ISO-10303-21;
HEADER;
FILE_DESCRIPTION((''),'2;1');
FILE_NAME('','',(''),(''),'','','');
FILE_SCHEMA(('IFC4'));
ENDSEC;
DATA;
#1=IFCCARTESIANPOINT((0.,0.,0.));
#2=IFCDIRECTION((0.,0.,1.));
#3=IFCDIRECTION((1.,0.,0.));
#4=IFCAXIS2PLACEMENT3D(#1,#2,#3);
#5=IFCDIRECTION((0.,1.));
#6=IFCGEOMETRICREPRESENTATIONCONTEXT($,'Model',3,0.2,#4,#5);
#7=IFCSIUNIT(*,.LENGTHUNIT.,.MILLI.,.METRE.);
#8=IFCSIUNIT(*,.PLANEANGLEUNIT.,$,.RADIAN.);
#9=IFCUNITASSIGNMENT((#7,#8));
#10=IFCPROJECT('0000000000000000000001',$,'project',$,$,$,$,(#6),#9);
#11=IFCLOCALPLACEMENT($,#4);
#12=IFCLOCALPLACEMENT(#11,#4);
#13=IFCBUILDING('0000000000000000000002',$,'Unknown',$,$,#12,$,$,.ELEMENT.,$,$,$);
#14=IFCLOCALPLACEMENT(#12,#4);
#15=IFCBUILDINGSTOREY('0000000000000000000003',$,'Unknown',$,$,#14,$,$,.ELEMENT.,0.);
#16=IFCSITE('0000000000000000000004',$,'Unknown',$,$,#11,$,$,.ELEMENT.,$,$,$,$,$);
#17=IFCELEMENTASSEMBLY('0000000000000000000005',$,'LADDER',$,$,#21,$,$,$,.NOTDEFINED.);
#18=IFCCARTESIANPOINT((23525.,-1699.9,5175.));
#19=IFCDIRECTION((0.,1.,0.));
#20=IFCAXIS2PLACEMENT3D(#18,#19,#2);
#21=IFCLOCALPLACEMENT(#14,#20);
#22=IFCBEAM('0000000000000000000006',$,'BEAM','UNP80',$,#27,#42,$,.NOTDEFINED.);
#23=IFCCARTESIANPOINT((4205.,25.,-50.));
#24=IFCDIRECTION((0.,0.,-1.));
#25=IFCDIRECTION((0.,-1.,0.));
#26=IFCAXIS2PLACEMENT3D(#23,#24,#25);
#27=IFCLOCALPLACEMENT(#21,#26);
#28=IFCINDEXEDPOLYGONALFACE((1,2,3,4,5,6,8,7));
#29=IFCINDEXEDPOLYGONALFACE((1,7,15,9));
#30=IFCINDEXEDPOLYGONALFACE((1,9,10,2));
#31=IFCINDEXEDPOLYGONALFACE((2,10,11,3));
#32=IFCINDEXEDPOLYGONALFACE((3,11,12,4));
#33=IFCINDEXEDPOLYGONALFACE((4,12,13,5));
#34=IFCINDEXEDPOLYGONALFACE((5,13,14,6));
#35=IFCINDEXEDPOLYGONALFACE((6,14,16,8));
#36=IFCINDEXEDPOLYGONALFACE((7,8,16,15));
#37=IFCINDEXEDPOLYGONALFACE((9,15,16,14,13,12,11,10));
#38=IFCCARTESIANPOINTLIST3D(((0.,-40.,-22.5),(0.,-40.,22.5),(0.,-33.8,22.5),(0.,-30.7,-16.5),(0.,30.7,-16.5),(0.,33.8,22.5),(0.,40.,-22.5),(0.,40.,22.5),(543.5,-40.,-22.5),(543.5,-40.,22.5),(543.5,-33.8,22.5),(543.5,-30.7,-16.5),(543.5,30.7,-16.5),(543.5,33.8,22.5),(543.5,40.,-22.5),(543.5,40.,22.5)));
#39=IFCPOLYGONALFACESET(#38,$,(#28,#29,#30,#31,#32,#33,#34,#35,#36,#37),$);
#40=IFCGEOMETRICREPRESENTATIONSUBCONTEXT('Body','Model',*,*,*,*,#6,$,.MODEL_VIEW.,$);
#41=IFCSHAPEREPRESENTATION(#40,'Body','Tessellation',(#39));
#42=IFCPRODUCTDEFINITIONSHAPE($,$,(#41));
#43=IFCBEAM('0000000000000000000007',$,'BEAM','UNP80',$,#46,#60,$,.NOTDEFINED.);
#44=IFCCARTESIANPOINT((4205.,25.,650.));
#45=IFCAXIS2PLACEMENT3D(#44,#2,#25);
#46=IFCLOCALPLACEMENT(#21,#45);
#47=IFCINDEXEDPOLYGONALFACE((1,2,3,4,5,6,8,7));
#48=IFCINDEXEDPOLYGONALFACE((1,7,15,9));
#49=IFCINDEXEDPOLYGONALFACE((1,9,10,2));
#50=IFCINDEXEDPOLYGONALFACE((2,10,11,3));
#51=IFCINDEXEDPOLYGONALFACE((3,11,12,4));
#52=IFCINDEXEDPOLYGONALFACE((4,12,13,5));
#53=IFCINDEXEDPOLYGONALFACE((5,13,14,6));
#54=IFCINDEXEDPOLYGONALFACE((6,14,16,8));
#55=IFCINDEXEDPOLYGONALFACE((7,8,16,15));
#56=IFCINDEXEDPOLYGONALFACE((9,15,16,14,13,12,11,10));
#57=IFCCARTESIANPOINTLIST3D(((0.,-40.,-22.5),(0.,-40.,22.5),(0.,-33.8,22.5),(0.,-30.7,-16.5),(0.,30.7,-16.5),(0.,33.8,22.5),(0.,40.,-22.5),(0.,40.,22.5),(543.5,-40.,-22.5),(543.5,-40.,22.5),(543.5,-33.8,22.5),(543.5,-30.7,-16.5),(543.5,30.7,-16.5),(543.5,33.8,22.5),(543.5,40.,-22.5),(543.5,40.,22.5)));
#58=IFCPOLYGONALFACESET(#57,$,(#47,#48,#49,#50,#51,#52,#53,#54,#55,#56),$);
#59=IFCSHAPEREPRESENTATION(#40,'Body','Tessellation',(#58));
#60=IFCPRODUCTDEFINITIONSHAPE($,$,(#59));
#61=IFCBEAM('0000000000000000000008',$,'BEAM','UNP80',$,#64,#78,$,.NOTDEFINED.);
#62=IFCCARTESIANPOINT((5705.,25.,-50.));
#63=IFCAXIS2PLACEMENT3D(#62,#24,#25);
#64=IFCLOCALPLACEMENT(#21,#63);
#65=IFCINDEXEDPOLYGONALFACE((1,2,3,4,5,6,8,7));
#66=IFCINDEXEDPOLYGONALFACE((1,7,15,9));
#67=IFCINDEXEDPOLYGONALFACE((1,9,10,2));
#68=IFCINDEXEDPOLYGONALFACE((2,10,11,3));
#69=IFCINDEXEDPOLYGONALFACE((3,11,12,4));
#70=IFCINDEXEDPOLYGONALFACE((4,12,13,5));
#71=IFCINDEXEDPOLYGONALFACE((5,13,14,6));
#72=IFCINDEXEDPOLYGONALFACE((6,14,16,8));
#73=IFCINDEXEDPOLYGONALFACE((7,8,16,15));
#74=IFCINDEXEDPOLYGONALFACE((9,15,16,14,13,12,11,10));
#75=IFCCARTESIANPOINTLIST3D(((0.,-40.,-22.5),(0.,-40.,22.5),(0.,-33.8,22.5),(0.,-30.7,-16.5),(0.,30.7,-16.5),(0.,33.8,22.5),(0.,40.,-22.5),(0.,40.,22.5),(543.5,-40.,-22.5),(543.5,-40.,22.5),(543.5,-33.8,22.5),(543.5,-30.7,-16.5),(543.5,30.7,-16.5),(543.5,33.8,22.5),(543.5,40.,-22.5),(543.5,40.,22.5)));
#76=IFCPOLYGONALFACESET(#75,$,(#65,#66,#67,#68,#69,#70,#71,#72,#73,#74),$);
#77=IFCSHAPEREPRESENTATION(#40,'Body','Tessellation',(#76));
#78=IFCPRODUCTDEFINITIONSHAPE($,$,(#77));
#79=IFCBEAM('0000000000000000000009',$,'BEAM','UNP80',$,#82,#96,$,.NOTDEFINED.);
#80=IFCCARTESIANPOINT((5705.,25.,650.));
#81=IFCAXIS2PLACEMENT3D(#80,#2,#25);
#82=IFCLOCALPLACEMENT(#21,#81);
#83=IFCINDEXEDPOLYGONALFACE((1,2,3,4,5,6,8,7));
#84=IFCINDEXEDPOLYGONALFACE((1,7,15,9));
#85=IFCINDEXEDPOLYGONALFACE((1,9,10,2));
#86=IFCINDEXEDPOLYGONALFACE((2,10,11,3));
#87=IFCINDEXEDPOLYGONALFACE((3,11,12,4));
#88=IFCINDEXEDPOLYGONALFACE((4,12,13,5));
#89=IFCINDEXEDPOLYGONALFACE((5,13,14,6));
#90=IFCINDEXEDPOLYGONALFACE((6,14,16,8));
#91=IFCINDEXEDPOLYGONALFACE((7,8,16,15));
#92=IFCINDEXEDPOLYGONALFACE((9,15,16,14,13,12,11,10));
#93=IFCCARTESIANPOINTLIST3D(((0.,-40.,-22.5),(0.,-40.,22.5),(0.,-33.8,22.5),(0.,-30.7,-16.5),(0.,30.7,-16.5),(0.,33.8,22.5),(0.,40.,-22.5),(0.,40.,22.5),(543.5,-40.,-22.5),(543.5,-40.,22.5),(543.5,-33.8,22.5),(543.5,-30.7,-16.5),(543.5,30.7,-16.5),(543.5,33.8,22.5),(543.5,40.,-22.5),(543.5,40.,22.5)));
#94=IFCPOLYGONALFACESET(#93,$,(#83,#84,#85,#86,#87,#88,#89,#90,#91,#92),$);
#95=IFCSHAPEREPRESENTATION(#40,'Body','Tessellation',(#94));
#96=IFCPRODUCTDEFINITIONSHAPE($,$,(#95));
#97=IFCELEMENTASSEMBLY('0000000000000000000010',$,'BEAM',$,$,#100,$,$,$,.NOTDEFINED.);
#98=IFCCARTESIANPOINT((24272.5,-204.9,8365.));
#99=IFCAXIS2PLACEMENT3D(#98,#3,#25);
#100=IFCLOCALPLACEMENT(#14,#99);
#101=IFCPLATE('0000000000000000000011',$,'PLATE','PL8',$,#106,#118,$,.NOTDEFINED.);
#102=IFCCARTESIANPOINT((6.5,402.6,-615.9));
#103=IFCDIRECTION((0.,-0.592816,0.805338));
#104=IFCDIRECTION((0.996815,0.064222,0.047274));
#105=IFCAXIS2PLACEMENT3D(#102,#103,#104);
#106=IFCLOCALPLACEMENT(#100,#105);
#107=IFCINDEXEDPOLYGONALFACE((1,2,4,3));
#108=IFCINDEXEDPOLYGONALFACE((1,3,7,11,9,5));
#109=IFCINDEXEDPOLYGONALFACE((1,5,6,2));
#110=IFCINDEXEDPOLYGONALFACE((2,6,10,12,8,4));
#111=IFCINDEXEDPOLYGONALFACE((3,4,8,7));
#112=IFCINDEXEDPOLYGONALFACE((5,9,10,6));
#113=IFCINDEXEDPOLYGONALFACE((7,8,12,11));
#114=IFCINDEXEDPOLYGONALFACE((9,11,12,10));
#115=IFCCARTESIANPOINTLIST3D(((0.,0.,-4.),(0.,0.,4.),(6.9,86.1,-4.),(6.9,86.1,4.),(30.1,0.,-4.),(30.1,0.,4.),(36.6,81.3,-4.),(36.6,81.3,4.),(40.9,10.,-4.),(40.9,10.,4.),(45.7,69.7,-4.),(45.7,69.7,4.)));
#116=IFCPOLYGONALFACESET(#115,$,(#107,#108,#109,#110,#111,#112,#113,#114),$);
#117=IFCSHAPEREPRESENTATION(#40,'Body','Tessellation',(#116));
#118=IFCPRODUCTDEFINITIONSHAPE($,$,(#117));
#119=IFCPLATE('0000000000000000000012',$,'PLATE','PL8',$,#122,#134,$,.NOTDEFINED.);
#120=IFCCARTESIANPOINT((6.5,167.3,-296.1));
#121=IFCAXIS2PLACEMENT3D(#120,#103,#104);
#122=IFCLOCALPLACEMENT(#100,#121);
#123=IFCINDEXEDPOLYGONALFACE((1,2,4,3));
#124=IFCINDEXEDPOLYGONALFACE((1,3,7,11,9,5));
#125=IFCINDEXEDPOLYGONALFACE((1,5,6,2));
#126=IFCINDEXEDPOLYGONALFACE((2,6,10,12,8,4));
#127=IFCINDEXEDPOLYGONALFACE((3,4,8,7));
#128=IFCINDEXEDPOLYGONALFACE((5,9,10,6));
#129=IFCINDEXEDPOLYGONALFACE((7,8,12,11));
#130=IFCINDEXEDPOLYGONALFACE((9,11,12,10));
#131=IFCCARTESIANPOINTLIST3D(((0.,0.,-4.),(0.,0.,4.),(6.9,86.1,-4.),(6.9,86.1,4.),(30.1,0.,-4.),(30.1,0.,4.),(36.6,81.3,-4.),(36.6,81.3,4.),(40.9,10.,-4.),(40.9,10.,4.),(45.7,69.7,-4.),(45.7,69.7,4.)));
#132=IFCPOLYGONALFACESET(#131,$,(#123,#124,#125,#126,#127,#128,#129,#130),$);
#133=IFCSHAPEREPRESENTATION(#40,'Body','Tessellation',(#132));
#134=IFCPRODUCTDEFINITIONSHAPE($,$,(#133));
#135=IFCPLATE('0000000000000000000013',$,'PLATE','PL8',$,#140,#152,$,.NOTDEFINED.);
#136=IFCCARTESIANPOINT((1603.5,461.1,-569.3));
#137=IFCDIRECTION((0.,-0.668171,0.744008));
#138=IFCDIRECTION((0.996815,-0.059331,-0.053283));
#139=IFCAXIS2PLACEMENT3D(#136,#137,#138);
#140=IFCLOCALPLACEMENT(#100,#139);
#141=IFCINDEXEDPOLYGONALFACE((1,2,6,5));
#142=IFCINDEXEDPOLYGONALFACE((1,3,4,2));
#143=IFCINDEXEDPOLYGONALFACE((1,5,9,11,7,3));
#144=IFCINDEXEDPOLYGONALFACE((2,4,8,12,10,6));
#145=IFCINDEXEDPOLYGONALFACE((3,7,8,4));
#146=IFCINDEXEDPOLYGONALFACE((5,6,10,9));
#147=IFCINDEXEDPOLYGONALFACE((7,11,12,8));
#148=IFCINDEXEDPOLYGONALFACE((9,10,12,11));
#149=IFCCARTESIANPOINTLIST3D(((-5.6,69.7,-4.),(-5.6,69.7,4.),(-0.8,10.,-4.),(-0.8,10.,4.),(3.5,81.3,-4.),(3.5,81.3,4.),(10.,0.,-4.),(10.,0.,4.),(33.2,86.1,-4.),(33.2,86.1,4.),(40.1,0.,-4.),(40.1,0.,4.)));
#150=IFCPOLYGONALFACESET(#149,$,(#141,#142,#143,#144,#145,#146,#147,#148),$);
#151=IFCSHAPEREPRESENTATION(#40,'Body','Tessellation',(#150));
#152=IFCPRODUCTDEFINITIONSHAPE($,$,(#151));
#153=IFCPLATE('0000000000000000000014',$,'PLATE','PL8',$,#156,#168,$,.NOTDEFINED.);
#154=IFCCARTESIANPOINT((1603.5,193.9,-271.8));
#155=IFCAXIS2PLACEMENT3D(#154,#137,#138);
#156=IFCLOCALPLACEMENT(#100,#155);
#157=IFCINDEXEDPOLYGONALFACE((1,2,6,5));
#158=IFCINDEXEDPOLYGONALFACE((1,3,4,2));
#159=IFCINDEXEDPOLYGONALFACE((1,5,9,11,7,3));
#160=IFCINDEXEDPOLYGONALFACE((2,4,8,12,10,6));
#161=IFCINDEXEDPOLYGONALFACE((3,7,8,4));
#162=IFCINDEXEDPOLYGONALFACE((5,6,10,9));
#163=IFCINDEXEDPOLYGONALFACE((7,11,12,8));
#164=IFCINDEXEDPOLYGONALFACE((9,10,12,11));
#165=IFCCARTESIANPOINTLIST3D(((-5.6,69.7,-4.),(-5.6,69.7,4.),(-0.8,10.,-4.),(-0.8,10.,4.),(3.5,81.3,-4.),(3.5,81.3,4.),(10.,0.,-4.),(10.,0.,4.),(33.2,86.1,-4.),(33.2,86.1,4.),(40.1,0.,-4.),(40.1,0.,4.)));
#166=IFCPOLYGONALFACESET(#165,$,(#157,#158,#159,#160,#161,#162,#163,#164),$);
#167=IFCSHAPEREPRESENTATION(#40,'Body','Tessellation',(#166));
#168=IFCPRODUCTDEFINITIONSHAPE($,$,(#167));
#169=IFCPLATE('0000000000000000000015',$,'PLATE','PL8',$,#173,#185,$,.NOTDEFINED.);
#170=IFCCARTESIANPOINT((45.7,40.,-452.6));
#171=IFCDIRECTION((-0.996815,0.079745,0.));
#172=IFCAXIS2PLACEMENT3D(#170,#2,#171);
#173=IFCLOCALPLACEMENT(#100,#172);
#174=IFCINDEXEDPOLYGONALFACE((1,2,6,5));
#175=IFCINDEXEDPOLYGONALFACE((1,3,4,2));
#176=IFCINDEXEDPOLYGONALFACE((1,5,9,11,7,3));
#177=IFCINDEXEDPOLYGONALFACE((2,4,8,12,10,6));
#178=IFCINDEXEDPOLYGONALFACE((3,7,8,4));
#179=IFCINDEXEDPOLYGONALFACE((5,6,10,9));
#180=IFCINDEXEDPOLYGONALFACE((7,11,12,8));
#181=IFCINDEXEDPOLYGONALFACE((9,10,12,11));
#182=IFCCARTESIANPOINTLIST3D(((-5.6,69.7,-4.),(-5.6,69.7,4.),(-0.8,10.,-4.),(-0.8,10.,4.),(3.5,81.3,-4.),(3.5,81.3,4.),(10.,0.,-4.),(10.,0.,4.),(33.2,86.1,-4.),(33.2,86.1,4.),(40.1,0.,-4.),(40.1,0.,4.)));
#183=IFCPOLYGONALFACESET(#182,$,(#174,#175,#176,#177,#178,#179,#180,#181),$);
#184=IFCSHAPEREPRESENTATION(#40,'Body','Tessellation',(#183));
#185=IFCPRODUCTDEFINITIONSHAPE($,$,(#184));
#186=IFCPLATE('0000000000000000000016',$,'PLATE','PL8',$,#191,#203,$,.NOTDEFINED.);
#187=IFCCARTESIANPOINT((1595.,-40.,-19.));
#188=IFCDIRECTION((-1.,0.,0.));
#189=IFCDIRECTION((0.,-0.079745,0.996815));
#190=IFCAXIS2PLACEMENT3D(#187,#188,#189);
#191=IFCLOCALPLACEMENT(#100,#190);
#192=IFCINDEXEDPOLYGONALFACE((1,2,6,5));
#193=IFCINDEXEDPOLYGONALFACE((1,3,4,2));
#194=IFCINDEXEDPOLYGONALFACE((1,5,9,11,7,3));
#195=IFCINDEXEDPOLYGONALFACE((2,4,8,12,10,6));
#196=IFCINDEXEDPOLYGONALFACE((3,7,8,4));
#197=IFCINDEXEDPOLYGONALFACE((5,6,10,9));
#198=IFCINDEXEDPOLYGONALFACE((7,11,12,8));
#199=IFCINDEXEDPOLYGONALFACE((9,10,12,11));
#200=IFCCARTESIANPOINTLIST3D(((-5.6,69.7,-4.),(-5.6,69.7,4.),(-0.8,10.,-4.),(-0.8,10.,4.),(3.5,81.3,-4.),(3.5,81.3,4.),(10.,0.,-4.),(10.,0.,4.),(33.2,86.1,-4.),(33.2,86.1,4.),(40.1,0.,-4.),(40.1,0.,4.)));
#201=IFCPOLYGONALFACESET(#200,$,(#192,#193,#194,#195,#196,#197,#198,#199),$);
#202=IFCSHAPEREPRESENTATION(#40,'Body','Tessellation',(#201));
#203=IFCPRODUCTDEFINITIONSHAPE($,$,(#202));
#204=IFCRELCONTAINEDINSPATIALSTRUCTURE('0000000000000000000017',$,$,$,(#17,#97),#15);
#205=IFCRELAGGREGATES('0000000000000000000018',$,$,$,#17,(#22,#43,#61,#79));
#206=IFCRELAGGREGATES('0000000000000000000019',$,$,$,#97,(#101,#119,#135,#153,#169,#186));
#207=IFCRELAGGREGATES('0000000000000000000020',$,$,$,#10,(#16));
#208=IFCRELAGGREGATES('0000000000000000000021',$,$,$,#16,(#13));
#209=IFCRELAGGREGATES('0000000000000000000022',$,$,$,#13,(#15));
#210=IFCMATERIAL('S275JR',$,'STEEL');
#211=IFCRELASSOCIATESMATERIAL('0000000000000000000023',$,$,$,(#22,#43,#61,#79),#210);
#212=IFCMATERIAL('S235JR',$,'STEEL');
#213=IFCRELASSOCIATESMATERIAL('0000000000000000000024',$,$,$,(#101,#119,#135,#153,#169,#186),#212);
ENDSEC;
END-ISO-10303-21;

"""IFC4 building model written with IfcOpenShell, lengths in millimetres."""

from ifc_helpers import new_model, si_unit, direction, frame, origin_with_axes, place, context, subcontext, project, spatial, line, indexed_curve, outline, extrude, material, element, aggregate, save


model = new_model("IFC4")

# Units and contexts
model_context = context("Model", 3, precision=0.2, world=origin_with_axes(), true_north=direction((0.0, 1.0)))
body_context = subcontext(model_context, "Body", "Model", "MODEL_VIEW")
ifc_project = project(units=[si_unit("LENGTHUNIT", "METRE", prefix="MILLI"), si_unit("PLANEANGLEUNIT", "RADIAN")], contexts=[model_context])

# Site, building, storey
site_placement = place(None, origin_with_axes())
site = spatial("IfcSite", under=ifc_project, at=site_placement, Name="Unknown", CompositionType="ELEMENT")
building_placement = place(site_placement, origin_with_axes())
building = spatial("IfcBuilding", under=site, at=building_placement, Name="Unknown", CompositionType="ELEMENT")
storey_placement = place(building_placement, origin_with_axes())
storey = spatial("IfcBuildingStorey", under=building, at=storey_placement, Name="Unknown", CompositionType="ELEMENT", Elevation=0.0)

# Element assembly, beams
assembly_1_placement = place(storey_placement, frame((23525.0, -1699.9, 5175.0), z_axis=(0.0, 1.0, 0.0), x_axis=(0.0, 0.0, 1.0)))
assembly_1 = element("IfcElementAssembly", 1, at=assembly_1_placement, inside=storey, Name="LADDER", PredefinedType="NOTDEFINED")
ifc_material_1 = material(Name="S275JR", Category="STEEL")
beam_1_placement = place(assembly_1_placement, frame((4205.0, 25.0, -50.0), z_axis=(0.0, 0.0, -1.0), x_axis=(0.0, -1.0, 0.0)))
beam_1 = element("IfcBeam", 2, at=beam_1_placement, material=ifc_material_1, Name="BEAM", Description="UNP80", PredefinedType="NOTDEFINED", context=body_context, shape_type="SolidModel", body=[
    extrude(outline(indexed_curve([(-22.5, -40.0), (22.5, -40.0), (22.5, -33.8), (-16.5, -30.7), (-16.5, 30.7), (22.5, 33.8), (22.5, 40.0), (-22.5, 40.0)], segments=[line(1, 2, 3, 4, 5, 6, 7, 8, 1)])), frame((0.0, 0.0, 0.0), z_axis=(-1.0, 0.0, 0.0), x_axis=(0.0, 0.0, 1.0)), (0.0, 0.0, -1.0), 543.5),
])
beam_2_placement = place(assembly_1_placement, frame((4205.0, 25.0, 650.0), z_axis=(0.0, 0.0, 1.0), x_axis=(0.0, -1.0, 0.0)))
beam_2 = element("IfcBeam", 3, at=beam_2_placement, material=ifc_material_1, Name="BEAM", Description="UNP80", PredefinedType="NOTDEFINED", context=body_context, shape_type="SolidModel", body=[
    extrude(outline(indexed_curve([(-22.5, -40.0), (22.5, -40.0), (22.5, -33.8), (-16.5, -30.7), (-16.5, 30.7), (22.5, 33.8), (22.5, 40.0), (-22.5, 40.0)], segments=[line(1, 2, 3, 4, 5, 6, 7, 8, 1)])), frame((0.0, 0.0, 0.0), z_axis=(-1.0, 0.0, 0.0), x_axis=(0.0, 0.0, 1.0)), (0.0, 0.0, -1.0), 543.5),
])
beam_3_placement = place(assembly_1_placement, frame((5705.0, 25.0, -50.0), z_axis=(0.0, 0.0, -1.0), x_axis=(0.0, -1.0, 0.0)))
beam_3 = element("IfcBeam", 4, at=beam_3_placement, material=ifc_material_1, Name="BEAM", Description="UNP80", PredefinedType="NOTDEFINED", context=body_context, shape_type="SolidModel", body=[
    extrude(outline(indexed_curve([(-22.5, -40.0), (22.5, -40.0), (22.5, -33.8), (-16.5, -30.7), (-16.5, 30.7), (22.5, 33.8), (22.5, 40.0), (-22.5, 40.0)], segments=[line(1, 2, 3, 4, 5, 6, 7, 8, 1)])), frame((0.0, 0.0, 0.0), z_axis=(-1.0, 0.0, 0.0), x_axis=(0.0, 0.0, 1.0)), (0.0, 0.0, -1.0), 543.5),
])
beam_4_placement = place(assembly_1_placement, frame((5705.0, 25.0, 650.0), z_axis=(0.0, 0.0, 1.0), x_axis=(0.0, -1.0, 0.0)))
beam_4 = element("IfcBeam", 5, at=beam_4_placement, material=ifc_material_1, Name="BEAM", Description="UNP80", PredefinedType="NOTDEFINED", context=body_context, shape_type="SolidModel", body=[
    extrude(outline(indexed_curve([(-22.5, -40.0), (22.5, -40.0), (22.5, -33.8), (-16.5, -30.7), (-16.5, 30.7), (22.5, 33.8), (22.5, 40.0), (-22.5, 40.0)], segments=[line(1, 2, 3, 4, 5, 6, 7, 8, 1)])), frame((0.0, 0.0, 0.0), z_axis=(-1.0, 0.0, 0.0), x_axis=(0.0, 0.0, 1.0)), (0.0, 0.0, -1.0), 543.5),
])
ifc_material_2 = material(Name="S235JR", Category="STEEL")

# Element assembly
assembly_2_placement = place(storey_placement, frame((24272.5, -204.9, 8365.0), z_axis=(1.0, 0.0, 0.0), x_axis=(0.0, -1.0, 0.0)))
assembly_2 = element("IfcElementAssembly", 6, at=assembly_2_placement, inside=storey, Name="BEAM", PredefinedType="NOTDEFINED")

# Plates
aggregate(assembly_1, [beam_1, beam_2, beam_3, beam_4])
plate_1_placement = place(assembly_2_placement, frame((6.5, 402.6, -615.9), z_axis=(0.0, -0.592816, 0.805338), x_axis=(0.996815, 0.064222, 0.047274)))
plate_1 = element("IfcPlate", 7, at=plate_1_placement, material=ifc_material_2, Name="PLATE", Description="PL8", PredefinedType="NOTDEFINED", context=body_context, shape_type="SolidModel", body=[
    extrude(outline(indexed_curve([(0.0, 0.0), (30.1, 0.0), (40.9, 10.0), (45.7, 69.7), (36.6, 81.3), (6.9, 86.1)], segments=[line(1, 2, 3, 4, 5, 6, 1)])), frame((0.0, 0.0, 4.0), z_axis=(0.0, 0.0, 1.0), x_axis=(1.0, 0.0, 0.0)), (0.0, 0.0, -1.0), 8.0),
])
plate_2_placement = place(assembly_2_placement, frame((6.5, 167.3, -296.1), z_axis=(0.0, -0.592816, 0.805338), x_axis=(0.996815, 0.064222, 0.047274)))
plate_2 = element("IfcPlate", 8, at=plate_2_placement, material=ifc_material_2, Name="PLATE", Description="PL8", PredefinedType="NOTDEFINED", context=body_context, shape_type="SolidModel", body=[
    extrude(outline(indexed_curve([(0.0, 0.0), (30.1, 0.0), (40.9, 10.0), (45.7, 69.7), (36.6, 81.3), (6.9, 86.1)], segments=[line(1, 2, 3, 4, 5, 6, 1)])), frame((0.0, 0.0, 4.0), z_axis=(0.0, 0.0, 1.0), x_axis=(1.0, 0.0, 0.0)), (0.0, 0.0, -1.0), 8.0),
])
plate_3_placement = place(assembly_2_placement, frame((1603.5, 461.1, -569.3), z_axis=(0.0, -0.668171, 0.744008), x_axis=(0.996815, -0.059331, -0.053283)))
plate_3 = element("IfcPlate", 9, at=plate_3_placement, material=ifc_material_2, Name="PLATE", Description="PL8", PredefinedType="NOTDEFINED", context=body_context, shape_type="SolidModel", body=[
    extrude(outline(indexed_curve([(-0.8, 10.0), (10.0, 0.0), (40.1, 0.0), (33.2, 86.1), (3.5, 81.3), (-5.6, 69.7)], segments=[line(1, 2, 3, 4, 5, 6, 1)])), frame((0.0, 0.0, 4.0), z_axis=(0.0, 0.0, 1.0), x_axis=(1.0, 0.0, 0.0)), (0.0, 0.0, -1.0), 8.0),
])
plate_4_placement = place(assembly_2_placement, frame((1603.5, 193.9, -271.8), z_axis=(0.0, -0.668171, 0.744008), x_axis=(0.996815, -0.059331, -0.053283)))
plate_4 = element("IfcPlate", 10, at=plate_4_placement, material=ifc_material_2, Name="PLATE", Description="PL8", PredefinedType="NOTDEFINED", context=body_context, shape_type="SolidModel", body=[
    extrude(outline(indexed_curve([(-0.8, 10.0), (10.0, 0.0), (40.1, 0.0), (33.2, 86.1), (3.5, 81.3), (-5.6, 69.7)], segments=[line(1, 2, 3, 4, 5, 6, 1)])), frame((0.0, 0.0, 4.0), z_axis=(0.0, 0.0, 1.0), x_axis=(1.0, 0.0, 0.0)), (0.0, 0.0, -1.0), 8.0),
])
plate_5_placement = place(assembly_2_placement, frame((45.7, 40.0, -452.6), z_axis=(0.0, 0.0, 1.0), x_axis=(-0.996815, 0.079745, 0.0)))
plate_5 = element("IfcPlate", 11, at=plate_5_placement, material=ifc_material_2, Name="PLATE", Description="PL8", PredefinedType="NOTDEFINED", context=body_context, shape_type="SolidModel", body=[
    extrude(outline(indexed_curve([(-0.8, 10.0), (10.0, 0.0), (40.1, 0.0), (33.2, 86.1), (3.5, 81.3), (-5.6, 69.7)], segments=[line(1, 2, 3, 4, 5, 6, 1)])), frame((0.0, 0.0, 4.0), z_axis=(0.0, 0.0, 1.0), x_axis=(1.0, 0.0, 0.0)), (0.0, 0.0, -1.0), 8.0),
])
plate_6_placement = place(assembly_2_placement, frame((1595.0, -40.0, -19.0), z_axis=(-1.0, 0.0, 0.0), x_axis=(0.0, -0.079745, 0.996815)))
plate_6 = element("IfcPlate", 12, at=plate_6_placement, material=ifc_material_2, Name="PLATE", Description="PL8", PredefinedType="NOTDEFINED", context=body_context, shape_type="SolidModel", body=[
    extrude(outline(indexed_curve([(-0.8, 10.0), (10.0, 0.0), (40.1, 0.0), (33.2, 86.1), (3.5, 81.3), (-5.6, 69.7)], segments=[line(1, 2, 3, 4, 5, 6, 1)])), frame((0.0, 0.0, 4.0), z_axis=(0.0, 0.0, 1.0), x_axis=(1.0, 0.0, 0.0)), (0.0, 0.0, -1.0), 8.0),
])
aggregate(assembly_2, [plate_1, plate_2, plate_3, plate_4, plate_5, plate_6])

save(model, "model.ifc")
